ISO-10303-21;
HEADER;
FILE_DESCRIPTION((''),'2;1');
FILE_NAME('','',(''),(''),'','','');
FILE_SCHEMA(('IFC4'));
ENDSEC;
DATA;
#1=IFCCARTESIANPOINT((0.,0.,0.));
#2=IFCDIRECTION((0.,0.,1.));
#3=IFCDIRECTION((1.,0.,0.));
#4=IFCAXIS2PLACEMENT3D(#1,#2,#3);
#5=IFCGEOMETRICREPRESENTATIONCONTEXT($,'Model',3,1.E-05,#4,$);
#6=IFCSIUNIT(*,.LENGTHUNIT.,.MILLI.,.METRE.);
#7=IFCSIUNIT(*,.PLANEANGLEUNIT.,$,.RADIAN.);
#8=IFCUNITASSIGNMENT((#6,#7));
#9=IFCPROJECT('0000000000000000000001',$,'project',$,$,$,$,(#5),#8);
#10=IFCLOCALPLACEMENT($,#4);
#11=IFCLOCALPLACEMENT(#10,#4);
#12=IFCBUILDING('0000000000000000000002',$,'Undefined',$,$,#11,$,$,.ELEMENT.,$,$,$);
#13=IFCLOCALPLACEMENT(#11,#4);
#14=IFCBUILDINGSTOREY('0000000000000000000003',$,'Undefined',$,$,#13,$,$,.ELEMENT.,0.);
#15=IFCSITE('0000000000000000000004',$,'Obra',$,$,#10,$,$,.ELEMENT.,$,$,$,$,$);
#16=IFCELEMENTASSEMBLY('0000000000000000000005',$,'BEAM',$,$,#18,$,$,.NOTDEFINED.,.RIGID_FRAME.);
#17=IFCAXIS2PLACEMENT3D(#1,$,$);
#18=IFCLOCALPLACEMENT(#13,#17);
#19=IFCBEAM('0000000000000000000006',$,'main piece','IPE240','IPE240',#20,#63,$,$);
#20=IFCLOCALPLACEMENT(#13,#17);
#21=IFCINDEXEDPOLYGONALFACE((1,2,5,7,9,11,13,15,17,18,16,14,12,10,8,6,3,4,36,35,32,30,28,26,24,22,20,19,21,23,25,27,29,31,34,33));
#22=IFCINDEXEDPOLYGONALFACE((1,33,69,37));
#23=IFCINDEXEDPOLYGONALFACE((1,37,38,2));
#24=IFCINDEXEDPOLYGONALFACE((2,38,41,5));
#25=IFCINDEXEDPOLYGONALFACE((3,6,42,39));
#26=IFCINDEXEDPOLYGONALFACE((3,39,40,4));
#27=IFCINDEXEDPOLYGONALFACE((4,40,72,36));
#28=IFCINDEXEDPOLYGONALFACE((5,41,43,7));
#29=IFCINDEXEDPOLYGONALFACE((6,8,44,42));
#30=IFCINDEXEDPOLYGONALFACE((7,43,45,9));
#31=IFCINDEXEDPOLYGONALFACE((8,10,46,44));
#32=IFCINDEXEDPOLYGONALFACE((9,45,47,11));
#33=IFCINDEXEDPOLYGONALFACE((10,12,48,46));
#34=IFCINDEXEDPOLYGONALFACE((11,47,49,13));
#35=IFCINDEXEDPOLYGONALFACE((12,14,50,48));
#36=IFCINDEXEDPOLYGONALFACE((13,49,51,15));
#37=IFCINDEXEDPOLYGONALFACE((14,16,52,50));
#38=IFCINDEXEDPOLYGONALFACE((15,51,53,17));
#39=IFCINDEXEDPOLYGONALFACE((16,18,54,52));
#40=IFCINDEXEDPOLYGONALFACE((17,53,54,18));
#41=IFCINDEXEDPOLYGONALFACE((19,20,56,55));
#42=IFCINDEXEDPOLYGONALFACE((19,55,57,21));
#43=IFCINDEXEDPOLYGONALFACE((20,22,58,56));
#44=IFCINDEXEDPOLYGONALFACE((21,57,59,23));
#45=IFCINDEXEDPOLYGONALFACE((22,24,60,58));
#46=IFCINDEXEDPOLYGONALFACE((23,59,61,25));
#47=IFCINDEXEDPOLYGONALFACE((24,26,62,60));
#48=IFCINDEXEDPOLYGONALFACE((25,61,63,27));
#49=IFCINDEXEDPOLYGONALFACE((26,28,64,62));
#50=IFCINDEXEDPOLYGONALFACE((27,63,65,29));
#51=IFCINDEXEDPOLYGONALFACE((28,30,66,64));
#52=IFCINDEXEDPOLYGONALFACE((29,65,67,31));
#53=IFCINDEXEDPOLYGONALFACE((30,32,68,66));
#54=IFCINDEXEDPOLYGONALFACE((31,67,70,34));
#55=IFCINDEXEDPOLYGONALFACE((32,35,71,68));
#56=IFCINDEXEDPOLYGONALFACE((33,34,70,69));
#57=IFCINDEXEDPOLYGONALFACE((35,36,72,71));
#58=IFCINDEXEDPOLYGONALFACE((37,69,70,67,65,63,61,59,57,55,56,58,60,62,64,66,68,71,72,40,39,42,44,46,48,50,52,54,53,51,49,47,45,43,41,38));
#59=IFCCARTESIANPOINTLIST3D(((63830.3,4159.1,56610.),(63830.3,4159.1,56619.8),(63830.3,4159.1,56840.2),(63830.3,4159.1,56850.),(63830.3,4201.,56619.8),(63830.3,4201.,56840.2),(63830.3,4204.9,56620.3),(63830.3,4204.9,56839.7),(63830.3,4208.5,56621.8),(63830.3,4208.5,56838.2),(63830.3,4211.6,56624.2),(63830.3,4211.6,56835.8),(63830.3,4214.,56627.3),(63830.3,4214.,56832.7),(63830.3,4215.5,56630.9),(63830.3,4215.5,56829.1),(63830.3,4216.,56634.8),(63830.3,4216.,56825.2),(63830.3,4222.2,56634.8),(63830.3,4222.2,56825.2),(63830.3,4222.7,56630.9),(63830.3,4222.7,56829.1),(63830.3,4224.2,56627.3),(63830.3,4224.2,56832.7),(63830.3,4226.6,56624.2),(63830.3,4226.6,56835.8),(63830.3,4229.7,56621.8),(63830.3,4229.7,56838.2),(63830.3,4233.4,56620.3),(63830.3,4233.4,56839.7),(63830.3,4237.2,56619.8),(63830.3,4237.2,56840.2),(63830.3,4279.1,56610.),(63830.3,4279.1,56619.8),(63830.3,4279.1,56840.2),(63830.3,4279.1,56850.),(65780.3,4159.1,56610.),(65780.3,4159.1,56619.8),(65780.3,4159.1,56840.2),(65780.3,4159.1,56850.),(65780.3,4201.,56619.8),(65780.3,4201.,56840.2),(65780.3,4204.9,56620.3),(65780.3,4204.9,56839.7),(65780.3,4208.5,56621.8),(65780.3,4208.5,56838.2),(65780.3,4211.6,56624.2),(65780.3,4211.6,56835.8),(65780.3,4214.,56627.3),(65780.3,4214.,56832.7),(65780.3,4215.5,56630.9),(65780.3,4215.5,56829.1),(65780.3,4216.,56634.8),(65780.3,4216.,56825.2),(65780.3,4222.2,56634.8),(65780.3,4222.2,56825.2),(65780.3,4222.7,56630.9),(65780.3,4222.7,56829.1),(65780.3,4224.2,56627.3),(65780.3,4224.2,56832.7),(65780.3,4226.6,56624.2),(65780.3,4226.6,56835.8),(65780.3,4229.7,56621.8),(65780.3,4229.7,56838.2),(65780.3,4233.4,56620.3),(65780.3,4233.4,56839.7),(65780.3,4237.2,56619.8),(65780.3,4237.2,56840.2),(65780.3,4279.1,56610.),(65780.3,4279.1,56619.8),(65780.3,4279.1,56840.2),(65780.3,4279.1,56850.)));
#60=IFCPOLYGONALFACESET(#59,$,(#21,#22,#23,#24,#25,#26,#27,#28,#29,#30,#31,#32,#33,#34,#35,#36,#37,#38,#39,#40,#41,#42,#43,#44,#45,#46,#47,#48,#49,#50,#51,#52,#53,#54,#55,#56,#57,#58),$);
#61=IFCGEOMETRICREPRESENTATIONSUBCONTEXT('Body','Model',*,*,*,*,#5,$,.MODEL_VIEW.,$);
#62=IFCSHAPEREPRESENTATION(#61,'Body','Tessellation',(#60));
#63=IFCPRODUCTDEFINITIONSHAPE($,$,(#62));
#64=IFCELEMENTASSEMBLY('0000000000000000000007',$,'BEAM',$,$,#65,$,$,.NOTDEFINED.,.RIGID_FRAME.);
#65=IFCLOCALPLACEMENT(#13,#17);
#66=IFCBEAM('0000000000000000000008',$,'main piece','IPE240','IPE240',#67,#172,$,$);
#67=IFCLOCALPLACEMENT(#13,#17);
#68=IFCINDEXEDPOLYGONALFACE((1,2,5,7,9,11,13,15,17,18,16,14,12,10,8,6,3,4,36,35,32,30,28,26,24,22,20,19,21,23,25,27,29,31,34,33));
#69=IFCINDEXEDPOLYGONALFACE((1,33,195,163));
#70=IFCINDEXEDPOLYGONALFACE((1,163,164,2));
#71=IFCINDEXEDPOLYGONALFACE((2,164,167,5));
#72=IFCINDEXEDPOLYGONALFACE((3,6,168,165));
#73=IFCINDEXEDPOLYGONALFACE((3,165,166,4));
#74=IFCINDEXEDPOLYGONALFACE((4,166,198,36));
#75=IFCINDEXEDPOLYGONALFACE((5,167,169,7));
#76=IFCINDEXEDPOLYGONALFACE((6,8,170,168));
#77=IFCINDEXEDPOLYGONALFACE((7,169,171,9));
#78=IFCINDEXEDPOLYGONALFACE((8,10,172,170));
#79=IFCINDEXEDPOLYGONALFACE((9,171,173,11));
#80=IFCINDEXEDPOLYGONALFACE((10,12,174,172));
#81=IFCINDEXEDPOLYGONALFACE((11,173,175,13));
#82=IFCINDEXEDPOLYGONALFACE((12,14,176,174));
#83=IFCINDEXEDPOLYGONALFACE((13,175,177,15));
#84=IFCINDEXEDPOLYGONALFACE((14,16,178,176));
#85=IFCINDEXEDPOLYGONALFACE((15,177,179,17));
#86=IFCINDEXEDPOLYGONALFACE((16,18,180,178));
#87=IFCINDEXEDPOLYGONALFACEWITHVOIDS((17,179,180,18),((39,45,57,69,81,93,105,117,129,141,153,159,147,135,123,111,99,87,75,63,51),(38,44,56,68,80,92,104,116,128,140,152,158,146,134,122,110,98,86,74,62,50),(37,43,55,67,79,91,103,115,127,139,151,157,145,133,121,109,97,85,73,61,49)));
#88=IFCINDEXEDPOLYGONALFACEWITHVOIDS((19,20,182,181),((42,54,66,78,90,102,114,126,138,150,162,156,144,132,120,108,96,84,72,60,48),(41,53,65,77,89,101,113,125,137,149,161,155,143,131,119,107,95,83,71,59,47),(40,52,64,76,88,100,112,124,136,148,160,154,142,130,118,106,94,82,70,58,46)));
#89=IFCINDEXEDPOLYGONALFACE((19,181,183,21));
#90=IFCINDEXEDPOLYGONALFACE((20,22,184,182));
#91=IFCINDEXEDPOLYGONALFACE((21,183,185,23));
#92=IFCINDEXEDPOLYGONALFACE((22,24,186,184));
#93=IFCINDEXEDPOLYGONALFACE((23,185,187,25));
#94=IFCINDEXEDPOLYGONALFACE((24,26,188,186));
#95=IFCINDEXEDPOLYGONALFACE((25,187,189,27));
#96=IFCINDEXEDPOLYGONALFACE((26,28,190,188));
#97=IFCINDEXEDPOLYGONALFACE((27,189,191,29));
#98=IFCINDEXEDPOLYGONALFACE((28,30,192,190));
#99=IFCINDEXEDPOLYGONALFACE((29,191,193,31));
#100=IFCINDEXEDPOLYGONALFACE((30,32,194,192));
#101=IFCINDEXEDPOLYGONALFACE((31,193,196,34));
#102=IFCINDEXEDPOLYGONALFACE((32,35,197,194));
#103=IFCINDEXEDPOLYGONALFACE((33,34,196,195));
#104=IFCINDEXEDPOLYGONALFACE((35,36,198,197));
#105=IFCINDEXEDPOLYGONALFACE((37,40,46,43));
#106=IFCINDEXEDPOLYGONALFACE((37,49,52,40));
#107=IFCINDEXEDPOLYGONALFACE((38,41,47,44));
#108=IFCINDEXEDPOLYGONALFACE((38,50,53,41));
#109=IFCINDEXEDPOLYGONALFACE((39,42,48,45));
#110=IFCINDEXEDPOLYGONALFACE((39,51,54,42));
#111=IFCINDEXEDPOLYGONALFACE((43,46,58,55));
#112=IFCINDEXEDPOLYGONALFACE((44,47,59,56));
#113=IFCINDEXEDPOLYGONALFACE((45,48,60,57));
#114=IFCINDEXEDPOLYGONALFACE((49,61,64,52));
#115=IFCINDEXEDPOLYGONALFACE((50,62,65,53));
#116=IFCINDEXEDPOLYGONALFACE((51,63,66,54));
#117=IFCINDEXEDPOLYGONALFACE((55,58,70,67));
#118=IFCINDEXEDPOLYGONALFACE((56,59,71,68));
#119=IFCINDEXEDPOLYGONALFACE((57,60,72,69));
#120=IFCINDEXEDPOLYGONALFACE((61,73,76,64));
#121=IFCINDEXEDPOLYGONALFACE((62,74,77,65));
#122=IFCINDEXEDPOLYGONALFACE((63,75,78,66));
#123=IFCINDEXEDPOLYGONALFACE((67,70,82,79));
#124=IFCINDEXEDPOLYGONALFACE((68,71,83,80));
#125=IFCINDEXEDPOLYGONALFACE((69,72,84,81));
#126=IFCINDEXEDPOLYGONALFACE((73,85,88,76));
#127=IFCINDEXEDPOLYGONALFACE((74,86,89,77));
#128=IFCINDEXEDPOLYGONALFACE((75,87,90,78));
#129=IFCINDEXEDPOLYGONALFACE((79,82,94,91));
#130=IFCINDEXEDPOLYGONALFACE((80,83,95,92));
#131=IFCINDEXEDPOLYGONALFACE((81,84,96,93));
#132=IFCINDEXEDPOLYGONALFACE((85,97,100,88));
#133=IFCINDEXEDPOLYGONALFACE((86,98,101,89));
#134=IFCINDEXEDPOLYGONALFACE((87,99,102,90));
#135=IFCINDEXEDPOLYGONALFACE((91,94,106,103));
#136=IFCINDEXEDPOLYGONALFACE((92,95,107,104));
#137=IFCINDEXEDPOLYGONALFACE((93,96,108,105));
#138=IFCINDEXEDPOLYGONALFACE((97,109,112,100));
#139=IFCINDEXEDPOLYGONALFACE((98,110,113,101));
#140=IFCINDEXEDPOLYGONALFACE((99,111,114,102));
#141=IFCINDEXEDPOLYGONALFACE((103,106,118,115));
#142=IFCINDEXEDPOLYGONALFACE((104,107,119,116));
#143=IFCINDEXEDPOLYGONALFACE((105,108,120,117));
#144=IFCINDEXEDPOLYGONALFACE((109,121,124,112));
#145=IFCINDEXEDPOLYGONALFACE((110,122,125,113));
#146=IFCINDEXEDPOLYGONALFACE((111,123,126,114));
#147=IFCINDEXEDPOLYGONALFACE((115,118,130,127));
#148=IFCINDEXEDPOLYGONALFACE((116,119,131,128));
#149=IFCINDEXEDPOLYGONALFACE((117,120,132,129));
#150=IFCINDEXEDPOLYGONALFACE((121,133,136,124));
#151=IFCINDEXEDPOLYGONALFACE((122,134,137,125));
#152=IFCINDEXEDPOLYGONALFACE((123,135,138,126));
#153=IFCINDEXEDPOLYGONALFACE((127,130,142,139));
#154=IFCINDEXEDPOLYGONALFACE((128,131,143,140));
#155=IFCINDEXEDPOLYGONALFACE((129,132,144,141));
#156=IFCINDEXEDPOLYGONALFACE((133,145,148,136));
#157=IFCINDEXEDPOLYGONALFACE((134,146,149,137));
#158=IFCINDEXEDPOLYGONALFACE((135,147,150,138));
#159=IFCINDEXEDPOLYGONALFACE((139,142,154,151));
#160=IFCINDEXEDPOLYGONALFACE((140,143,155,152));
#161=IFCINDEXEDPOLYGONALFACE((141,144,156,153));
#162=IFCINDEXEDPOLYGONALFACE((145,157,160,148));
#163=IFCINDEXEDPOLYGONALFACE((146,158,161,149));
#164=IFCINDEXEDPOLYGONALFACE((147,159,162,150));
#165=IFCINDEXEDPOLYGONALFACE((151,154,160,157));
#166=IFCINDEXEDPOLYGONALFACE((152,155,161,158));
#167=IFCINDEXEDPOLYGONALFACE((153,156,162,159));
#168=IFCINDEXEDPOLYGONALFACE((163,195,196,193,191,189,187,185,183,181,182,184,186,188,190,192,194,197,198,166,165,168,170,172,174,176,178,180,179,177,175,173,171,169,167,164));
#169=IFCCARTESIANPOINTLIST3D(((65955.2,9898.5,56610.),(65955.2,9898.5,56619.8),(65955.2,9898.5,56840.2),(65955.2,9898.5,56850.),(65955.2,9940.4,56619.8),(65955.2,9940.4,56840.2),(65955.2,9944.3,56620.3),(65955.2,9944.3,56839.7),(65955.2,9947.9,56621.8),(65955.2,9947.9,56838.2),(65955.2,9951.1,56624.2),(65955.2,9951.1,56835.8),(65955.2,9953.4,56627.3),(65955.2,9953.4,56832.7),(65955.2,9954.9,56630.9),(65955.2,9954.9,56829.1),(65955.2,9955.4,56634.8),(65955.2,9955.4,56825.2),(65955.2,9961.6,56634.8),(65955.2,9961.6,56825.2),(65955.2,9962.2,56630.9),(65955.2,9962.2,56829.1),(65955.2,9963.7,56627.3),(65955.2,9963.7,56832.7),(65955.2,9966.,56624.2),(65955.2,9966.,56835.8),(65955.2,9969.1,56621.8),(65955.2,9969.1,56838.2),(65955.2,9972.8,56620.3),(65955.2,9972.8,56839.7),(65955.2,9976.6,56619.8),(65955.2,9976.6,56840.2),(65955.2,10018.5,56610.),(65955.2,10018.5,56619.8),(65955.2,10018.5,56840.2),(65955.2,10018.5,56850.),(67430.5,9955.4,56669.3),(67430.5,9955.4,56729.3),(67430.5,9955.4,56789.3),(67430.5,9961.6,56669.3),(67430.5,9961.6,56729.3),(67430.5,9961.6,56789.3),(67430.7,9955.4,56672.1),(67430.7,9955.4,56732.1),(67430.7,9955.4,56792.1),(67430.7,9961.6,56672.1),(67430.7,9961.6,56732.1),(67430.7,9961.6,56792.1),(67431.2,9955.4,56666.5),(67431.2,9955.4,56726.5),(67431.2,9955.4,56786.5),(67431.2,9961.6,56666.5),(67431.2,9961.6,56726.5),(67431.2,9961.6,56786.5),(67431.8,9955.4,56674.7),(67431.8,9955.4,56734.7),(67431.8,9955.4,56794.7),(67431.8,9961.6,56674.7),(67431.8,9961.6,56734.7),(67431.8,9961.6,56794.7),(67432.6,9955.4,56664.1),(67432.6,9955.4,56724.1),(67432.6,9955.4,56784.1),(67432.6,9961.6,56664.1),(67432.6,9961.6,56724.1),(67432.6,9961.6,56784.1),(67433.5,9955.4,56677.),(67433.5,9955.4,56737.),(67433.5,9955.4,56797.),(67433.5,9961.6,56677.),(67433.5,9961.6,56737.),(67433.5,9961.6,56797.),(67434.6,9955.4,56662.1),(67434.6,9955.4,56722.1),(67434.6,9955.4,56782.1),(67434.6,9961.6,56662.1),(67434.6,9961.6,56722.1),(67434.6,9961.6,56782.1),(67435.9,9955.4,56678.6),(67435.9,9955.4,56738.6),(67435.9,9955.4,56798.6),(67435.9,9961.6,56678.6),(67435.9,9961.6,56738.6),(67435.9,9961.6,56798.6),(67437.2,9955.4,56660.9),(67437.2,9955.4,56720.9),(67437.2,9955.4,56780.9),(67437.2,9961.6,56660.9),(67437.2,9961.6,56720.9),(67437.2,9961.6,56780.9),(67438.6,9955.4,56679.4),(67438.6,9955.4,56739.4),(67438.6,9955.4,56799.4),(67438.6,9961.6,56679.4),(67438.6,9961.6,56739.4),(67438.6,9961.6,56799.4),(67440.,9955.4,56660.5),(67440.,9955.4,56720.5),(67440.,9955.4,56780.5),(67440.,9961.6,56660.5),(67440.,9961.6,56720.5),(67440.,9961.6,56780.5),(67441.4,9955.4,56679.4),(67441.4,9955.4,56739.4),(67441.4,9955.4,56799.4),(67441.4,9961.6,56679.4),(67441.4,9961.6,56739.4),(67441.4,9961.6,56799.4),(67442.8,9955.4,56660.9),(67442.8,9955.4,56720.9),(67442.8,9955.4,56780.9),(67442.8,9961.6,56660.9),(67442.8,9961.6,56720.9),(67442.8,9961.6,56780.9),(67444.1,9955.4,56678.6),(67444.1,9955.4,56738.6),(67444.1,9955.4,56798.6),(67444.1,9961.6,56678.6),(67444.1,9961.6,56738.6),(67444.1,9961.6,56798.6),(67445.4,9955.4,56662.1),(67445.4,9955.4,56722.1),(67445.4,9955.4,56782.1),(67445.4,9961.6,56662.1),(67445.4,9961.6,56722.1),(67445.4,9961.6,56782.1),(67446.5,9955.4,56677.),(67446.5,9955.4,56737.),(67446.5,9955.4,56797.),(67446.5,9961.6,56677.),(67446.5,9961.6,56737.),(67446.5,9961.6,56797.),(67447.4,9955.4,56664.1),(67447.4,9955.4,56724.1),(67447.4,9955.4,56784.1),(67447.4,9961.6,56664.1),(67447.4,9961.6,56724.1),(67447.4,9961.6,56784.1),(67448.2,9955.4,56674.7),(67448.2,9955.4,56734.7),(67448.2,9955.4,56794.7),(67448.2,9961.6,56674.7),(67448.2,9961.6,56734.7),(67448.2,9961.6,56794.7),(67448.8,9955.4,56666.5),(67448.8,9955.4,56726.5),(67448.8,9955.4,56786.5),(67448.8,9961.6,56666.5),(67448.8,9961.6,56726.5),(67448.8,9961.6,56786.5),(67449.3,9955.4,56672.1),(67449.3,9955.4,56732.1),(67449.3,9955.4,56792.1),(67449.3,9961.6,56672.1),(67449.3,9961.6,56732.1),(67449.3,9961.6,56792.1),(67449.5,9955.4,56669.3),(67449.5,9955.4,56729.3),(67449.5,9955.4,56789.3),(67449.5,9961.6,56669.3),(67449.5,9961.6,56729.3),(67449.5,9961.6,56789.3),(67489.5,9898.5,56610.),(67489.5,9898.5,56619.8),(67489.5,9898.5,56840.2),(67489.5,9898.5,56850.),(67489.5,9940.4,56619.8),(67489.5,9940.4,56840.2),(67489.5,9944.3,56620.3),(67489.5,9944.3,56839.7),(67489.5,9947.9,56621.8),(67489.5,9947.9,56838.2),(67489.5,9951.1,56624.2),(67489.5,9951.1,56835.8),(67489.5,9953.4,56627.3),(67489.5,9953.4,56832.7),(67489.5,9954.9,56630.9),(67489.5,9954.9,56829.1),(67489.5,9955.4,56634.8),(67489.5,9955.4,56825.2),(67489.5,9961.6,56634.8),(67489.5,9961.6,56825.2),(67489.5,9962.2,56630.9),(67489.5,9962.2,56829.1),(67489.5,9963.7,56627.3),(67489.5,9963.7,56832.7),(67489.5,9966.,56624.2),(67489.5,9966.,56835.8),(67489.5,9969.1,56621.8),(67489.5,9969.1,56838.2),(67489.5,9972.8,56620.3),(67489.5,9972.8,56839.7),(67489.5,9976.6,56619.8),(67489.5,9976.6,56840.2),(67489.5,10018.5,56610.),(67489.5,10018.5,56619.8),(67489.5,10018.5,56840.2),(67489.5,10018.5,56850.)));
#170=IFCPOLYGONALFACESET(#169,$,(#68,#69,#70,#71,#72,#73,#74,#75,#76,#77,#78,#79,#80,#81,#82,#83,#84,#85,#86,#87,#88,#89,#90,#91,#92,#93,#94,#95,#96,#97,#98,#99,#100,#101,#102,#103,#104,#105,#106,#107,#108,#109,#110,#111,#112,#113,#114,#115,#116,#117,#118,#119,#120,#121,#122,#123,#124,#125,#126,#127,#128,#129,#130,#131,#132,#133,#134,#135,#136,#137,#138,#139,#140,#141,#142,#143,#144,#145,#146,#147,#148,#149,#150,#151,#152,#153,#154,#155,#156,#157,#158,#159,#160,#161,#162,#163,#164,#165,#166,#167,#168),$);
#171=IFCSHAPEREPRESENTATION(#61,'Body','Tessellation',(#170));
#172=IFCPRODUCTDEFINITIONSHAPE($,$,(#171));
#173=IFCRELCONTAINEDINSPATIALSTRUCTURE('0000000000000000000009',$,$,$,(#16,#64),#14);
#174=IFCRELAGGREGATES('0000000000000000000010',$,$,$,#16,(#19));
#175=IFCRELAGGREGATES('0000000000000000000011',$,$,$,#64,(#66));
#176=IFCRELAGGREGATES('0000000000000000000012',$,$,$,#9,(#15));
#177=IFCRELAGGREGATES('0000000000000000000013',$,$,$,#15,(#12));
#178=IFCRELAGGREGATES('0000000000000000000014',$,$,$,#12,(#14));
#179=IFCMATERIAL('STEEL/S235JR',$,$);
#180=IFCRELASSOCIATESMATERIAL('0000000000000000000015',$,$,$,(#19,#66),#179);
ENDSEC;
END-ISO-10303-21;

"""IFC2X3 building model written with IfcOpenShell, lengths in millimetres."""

from ifc_helpers import new_model, si_unit, frame, origin_with_axes, origin_2d_with_axis, place, context, subcontext, project, spatial, circle, i_section, extrude, clip, halfspace, source, transform, mapped, material, element, aggregate, save


model = new_model("IFC2X3")

# Units and contexts
model_context = context("Model", 3, precision=1e-05, world=origin_with_axes())
body_context = subcontext(model_context, "Body", "Model", "MODEL_VIEW")
ifc_project = project(units=[si_unit("LENGTHUNIT", "METRE", prefix="MILLI"), si_unit("PLANEANGLEUNIT", "RADIAN")], contexts=[model_context])

# Site, building, storey
site_placement = place(None, origin_with_axes())
site = spatial("IfcSite", under=ifc_project, at=site_placement, Name="Obra", CompositionType="ELEMENT")
building_placement = place(site_placement, origin_with_axes())
building = spatial("IfcBuilding", under=site, at=building_placement, Name="Undefined", CompositionType="ELEMENT")
storey_placement = place(building_placement, origin_with_axes())
storey = spatial("IfcBuildingStorey", under=building, at=storey_placement, Name="Undefined", CompositionType="ELEMENT", Elevation=0.0)

# Shared definitions
ifc_material_1 = material(Name="STEEL/S235JR")

# Element assembly, beam
assembly_1_placement = place(storey_placement, origin_with_axes())
assembly_1 = element("IfcElementAssembly", 1, at=assembly_1_placement, inside=storey, Name="BEAM", AssemblyPlace="NOTDEFINED", PredefinedType="RIGID_FRAME")
beam_1_placement = place(assembly_1_placement, frame((63830.3, 4219.1, 56730.0), z_axis=(0.0, 0.0, 1.0), x_axis=(1.0, 0.0, 0.0)))
beam_1 = element("IfcBeam", 2, at=beam_1_placement, material=ifc_material_1, Name="main piece", Description="IPE240", ObjectType="IPE240", context=body_context, shape_type="SweptSolid", body=[
    extrude(i_section(OverallWidth=120.0, OverallDepth=240.0, WebThickness=6.2, FlangeThickness=9.8, FilletRadius=15.0, at=origin_2d_with_axis()), frame((1950.0, 0.0, 0.0), z_axis=(-1.0, 0.0, 0.0), x_axis=(0.0, -1.0, 0.0)), (0.0, 0.0, 1.0), 1950.0),
])
aggregate(assembly_1, [beam_1])

# Element assembly, beam, opening
assembly_2_placement = place(storey_placement, origin_with_axes())
assembly_2 = element("IfcElementAssembly", 3, at=assembly_2_placement, inside=storey, Name="BEAM", AssemblyPlace="NOTDEFINED", PredefinedType="RIGID_FRAME")
beam_2_placement = place(assembly_2_placement, frame((65955.2, 9958.5, 56730.0), z_axis=(0.0, 0.0, 1.0), x_axis=(1.0, 0.000002, 0.0)))
beam_2 = element("IfcBeam", 4, at=beam_2_placement, material=ifc_material_1, Name="main piece", Description="IPE240", ObjectType="IPE240", context=body_context, shape_type="Clipping", body=[
    clip(extrude(i_section(OverallWidth=120.0, OverallDepth=240.0, WebThickness=6.2, FlangeThickness=9.8, FilletRadius=15.0, at=origin_2d_with_axis()), frame((1819.9, 0.0, 0.0), z_axis=(-1.0, 0.0, 0.0), x_axis=(0.0, -1.0, 0.0)), (0.0, 0.0, 1.0), 1819.9), halfspace(frame((1534.3, -60.0, -120.0), z_axis=(1.0, 0.000017, 0.0), x_axis=(0.0, 0.0, 1.0)), False)),
])
shared_shape_1 = source(origin_with_axes(), body_context, "Body", "SweptSolid", [
    extrude(circle(Radius=9.5, at=origin_2d_with_axis()), frame((0.0, -3.2, 0.0), z_axis=(0.0, 1.0, 0.0), x_axis=(1.0, 0.0, 0.0)), (0.0, 0.0, 1.0), 6.4),
])
opening_1_placement = place(assembly_2_placement, frame((67490.0, 9958.5, 56850.0), z_axis=(-1.0, 0.0, 0.0), x_axis=(0.0, 0.0, -1.0)))
element("IfcOpeningElement", 5, at=opening_1_placement, cuts=beam_2, ObjectType="Opening", context=body_context, shape_type="MappedRepresentation", body=[
    mapped(shared_shape_1, transform((60.0, 0.0, 50.0))),
    mapped(shared_shape_1, transform((120.0, 0.0, 50.0))),
    mapped(shared_shape_1, transform((180.0, 0.0, 50.0))),
])
aggregate(assembly_2, [beam_2])

save(model, "model.ifc")
